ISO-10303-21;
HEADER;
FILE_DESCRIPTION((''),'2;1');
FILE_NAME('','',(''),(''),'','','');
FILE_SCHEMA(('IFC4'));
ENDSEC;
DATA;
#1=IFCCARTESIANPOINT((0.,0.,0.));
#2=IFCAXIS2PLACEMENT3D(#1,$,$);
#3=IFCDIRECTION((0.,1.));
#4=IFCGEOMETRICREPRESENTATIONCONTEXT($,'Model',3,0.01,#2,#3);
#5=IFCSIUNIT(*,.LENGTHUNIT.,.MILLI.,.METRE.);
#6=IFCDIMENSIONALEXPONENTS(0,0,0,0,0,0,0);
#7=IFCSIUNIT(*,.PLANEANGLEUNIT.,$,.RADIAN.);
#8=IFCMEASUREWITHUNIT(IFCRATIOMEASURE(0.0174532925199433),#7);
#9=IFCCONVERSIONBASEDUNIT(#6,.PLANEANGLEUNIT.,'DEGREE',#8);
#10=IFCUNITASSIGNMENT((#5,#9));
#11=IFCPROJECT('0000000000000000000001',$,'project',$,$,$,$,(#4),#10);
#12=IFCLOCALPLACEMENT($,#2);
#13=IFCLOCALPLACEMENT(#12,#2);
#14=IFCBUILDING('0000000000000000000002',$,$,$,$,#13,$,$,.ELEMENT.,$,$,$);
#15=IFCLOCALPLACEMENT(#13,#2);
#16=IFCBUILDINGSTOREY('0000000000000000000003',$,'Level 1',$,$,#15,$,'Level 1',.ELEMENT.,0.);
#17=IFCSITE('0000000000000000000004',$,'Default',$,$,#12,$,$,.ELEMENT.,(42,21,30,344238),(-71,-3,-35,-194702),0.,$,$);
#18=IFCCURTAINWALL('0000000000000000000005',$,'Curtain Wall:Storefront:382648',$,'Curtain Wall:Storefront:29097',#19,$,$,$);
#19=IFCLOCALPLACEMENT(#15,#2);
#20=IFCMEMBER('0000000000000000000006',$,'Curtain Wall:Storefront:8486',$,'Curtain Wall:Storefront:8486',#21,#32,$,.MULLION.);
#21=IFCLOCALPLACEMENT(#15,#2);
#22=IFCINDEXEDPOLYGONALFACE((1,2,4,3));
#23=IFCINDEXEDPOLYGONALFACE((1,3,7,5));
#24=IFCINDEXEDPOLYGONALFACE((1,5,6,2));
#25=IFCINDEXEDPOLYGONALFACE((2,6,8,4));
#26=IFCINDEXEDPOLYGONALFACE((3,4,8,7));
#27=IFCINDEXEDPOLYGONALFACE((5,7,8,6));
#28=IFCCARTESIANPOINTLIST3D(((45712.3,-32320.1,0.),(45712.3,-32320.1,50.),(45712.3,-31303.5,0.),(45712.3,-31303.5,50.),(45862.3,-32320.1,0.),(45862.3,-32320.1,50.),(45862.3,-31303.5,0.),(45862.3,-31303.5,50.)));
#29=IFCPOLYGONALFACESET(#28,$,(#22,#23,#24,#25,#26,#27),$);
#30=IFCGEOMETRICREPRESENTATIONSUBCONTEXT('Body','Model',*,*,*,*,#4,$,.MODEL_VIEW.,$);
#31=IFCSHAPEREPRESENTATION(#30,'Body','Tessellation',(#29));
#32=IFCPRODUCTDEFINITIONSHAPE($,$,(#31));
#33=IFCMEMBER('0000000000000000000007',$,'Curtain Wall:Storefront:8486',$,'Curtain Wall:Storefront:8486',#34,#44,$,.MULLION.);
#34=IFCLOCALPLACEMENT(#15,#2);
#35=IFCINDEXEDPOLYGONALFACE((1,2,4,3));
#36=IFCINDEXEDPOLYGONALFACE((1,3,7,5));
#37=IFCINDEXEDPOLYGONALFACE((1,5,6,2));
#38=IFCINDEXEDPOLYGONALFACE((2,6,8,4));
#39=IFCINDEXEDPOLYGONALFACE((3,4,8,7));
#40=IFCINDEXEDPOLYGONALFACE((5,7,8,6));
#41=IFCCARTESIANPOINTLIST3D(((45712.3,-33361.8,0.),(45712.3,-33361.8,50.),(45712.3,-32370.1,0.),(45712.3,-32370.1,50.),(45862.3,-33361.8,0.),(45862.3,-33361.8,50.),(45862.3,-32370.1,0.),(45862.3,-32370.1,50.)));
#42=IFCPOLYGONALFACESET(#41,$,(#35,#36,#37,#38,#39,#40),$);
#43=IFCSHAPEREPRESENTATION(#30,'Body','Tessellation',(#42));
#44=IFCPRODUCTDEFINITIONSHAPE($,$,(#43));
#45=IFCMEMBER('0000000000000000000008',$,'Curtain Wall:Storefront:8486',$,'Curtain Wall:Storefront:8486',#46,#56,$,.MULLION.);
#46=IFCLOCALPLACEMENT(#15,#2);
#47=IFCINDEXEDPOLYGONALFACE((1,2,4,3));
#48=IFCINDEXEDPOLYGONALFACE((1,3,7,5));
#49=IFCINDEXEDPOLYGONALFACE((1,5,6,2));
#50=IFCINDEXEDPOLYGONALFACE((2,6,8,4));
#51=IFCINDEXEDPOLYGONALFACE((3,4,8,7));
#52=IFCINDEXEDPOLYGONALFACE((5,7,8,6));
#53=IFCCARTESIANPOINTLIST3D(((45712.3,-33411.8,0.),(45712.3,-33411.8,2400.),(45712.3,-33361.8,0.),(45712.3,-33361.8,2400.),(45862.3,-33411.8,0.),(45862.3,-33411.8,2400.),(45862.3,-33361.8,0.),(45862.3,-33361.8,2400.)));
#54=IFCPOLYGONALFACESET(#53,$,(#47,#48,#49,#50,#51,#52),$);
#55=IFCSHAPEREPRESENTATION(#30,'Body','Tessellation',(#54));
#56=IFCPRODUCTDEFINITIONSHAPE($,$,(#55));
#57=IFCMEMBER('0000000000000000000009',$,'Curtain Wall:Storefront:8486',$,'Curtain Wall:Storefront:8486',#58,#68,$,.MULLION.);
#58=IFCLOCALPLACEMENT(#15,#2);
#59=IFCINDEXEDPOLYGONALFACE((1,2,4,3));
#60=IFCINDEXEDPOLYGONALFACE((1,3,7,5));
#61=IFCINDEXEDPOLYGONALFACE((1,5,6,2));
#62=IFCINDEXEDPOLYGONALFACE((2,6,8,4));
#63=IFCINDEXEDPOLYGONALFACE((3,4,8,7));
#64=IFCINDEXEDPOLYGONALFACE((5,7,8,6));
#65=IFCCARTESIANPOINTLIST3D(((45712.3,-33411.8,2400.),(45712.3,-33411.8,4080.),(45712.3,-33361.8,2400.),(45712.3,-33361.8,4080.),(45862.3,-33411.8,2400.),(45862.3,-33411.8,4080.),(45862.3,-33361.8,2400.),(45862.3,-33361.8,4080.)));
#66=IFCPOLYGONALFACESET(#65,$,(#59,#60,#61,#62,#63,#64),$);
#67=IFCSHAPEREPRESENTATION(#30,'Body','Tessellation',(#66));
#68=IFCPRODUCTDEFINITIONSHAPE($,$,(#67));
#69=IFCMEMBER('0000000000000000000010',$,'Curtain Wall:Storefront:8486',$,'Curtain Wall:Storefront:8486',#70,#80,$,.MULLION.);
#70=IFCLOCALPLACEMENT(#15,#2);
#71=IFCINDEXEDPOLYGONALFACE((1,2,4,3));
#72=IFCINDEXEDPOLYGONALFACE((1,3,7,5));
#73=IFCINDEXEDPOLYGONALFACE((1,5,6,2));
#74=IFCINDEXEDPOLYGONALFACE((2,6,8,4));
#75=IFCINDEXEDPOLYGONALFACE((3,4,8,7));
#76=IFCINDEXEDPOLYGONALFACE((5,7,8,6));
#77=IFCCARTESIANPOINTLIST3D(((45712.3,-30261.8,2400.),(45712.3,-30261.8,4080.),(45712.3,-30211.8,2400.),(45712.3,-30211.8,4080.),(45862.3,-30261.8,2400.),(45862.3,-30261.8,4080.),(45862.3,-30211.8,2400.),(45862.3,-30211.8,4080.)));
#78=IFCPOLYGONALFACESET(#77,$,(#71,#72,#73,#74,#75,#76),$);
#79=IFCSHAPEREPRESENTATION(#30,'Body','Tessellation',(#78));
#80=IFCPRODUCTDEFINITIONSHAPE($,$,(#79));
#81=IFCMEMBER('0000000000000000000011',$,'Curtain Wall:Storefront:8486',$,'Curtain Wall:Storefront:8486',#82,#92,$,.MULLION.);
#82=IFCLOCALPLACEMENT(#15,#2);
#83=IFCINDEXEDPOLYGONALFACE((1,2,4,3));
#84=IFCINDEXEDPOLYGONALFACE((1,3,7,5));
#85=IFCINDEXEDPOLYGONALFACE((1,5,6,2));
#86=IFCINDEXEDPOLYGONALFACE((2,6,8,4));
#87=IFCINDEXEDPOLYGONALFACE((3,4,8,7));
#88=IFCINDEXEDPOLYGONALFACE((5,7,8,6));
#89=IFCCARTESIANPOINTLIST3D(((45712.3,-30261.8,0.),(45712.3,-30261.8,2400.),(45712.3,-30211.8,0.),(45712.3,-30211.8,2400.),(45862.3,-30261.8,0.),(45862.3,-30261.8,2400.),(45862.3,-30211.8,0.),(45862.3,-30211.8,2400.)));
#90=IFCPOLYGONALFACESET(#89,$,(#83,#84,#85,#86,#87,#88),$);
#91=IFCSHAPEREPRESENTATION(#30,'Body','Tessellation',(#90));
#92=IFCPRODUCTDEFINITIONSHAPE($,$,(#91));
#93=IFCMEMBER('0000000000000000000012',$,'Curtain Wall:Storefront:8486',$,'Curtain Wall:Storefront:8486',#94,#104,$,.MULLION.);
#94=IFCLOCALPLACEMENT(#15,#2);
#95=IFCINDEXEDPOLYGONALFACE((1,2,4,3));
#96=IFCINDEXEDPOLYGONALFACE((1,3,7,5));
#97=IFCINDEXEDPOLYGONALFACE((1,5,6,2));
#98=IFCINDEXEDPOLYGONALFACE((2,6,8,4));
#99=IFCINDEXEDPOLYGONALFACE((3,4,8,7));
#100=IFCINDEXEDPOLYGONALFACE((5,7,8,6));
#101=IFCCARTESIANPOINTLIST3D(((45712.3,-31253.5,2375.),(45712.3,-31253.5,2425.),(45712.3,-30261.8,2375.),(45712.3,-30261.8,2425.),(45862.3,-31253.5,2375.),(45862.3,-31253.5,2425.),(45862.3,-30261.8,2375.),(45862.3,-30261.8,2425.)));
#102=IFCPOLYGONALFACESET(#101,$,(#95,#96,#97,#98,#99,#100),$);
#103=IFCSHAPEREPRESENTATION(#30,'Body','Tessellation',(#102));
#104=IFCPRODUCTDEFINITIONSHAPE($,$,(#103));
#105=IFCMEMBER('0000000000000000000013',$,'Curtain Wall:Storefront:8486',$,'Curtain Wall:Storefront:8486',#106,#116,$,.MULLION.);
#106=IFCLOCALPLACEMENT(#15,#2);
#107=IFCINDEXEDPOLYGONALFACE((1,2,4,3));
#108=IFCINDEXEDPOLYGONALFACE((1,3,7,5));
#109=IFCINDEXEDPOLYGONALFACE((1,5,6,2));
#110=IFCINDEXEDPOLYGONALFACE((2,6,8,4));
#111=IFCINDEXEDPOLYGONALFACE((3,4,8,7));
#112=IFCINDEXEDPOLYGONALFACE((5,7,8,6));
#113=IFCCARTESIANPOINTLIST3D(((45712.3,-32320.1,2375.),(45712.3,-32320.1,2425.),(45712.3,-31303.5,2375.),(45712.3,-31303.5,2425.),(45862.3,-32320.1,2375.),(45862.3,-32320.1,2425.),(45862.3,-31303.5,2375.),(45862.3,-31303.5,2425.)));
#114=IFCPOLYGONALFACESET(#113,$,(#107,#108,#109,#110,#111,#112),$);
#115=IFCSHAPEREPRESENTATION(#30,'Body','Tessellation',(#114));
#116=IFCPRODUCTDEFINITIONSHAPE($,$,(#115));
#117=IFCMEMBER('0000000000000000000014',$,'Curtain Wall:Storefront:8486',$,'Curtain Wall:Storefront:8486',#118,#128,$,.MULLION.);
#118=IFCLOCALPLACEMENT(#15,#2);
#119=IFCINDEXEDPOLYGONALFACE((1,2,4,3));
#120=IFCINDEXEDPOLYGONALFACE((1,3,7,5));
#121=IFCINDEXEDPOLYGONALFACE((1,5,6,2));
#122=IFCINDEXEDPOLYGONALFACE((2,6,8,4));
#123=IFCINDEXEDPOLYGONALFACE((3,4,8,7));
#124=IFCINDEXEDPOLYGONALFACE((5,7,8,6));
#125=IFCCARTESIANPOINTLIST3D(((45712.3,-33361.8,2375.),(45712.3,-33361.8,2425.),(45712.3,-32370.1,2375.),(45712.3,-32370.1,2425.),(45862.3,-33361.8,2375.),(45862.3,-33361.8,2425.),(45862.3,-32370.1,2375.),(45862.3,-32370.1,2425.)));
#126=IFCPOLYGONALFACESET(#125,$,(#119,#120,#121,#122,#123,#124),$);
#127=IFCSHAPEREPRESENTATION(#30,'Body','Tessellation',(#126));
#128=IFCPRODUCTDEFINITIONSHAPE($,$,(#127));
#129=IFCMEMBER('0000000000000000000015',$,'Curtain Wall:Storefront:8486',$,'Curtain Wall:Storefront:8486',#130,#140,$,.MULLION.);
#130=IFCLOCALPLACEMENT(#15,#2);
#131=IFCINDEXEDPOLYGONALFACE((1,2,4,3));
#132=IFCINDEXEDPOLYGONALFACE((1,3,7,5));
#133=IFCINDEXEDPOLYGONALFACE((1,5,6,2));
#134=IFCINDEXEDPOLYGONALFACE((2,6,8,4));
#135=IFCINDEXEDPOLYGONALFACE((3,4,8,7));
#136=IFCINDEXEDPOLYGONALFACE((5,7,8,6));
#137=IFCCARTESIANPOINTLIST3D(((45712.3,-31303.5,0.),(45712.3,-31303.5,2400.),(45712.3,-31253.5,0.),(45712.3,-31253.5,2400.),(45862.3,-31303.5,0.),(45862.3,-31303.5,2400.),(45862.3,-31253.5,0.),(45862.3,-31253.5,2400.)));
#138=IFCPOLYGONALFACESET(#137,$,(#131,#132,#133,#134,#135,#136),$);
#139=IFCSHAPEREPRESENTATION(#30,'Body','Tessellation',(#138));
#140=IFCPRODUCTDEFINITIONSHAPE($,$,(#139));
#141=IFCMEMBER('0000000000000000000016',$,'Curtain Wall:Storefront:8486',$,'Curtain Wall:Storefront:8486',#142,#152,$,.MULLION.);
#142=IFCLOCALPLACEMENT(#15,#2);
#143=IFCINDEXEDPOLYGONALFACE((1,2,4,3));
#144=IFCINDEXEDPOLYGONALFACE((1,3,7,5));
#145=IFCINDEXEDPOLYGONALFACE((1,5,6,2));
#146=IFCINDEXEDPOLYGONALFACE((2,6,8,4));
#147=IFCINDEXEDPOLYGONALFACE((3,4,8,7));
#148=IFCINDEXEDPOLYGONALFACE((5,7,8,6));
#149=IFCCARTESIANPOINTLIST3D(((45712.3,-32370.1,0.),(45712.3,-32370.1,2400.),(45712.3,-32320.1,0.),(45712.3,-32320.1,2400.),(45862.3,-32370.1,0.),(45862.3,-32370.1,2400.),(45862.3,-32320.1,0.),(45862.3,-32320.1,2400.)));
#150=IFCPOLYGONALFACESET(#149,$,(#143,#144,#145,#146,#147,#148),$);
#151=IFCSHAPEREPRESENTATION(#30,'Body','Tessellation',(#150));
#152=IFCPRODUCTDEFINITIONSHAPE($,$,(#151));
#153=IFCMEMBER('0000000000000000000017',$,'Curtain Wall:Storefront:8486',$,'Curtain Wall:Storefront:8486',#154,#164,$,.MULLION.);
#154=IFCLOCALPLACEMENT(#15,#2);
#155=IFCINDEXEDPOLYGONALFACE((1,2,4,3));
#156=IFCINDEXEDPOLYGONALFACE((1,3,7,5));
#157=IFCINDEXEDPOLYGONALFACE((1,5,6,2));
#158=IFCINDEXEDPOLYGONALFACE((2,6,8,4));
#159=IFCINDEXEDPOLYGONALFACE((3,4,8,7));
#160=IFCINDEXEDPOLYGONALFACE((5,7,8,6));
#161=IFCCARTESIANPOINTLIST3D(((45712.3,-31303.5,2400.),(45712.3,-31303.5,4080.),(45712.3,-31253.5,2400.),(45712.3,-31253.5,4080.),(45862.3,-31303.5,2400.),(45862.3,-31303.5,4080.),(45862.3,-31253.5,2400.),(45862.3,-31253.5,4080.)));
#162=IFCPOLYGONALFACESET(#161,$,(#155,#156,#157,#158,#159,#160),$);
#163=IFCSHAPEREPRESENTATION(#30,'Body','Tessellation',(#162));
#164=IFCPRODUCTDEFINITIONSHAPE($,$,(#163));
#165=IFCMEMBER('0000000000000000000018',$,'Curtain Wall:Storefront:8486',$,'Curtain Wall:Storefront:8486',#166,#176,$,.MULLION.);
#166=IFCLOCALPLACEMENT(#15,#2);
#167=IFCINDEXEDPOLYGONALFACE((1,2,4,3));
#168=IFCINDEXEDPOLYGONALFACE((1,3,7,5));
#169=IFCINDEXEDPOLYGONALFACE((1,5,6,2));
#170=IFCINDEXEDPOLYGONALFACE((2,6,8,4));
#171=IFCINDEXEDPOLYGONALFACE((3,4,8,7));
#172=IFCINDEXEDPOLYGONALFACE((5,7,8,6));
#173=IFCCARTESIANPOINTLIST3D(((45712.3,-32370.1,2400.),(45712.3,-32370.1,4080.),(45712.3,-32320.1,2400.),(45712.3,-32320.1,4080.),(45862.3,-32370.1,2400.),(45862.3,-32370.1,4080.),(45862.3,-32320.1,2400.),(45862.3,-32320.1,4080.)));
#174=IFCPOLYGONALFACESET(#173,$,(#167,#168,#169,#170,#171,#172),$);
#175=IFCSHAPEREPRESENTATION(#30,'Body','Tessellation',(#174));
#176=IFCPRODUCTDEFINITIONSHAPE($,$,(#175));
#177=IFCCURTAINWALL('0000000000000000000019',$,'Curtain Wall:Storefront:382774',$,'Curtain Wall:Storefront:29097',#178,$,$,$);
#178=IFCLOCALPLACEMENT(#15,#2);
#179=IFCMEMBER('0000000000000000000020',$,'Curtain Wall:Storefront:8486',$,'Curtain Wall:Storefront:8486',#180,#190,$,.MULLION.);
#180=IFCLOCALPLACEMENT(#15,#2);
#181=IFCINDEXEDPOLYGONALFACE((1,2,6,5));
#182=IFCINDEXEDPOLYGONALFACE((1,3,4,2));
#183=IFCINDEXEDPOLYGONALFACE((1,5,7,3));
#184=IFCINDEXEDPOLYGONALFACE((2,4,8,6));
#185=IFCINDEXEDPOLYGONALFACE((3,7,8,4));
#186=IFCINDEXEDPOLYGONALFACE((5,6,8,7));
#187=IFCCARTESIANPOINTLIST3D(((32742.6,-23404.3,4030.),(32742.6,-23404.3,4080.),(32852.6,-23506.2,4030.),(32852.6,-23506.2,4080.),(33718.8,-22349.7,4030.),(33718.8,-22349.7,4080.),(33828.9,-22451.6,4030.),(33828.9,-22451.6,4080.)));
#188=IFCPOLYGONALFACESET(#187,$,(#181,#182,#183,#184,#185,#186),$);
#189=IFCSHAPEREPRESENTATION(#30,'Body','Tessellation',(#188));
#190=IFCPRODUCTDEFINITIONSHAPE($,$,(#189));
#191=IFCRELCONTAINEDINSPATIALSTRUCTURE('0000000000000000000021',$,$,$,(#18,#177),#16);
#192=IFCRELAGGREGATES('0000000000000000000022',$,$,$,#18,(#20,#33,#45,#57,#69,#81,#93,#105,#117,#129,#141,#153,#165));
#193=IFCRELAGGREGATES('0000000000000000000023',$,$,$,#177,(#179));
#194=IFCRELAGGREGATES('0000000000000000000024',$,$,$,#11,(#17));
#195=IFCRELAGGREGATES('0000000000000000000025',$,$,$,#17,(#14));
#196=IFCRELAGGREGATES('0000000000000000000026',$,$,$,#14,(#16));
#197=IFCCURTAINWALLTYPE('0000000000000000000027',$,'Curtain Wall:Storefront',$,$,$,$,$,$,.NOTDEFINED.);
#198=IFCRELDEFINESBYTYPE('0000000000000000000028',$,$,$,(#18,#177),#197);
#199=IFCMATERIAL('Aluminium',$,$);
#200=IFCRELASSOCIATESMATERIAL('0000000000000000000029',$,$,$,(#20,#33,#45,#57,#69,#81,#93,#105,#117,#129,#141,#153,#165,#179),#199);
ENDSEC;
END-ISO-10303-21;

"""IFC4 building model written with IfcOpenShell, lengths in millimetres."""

from ifc_helpers import new_model, entity, si_unit, converted_unit, direction, frame, frame_2d, origin, origin_2d_with_axis, place, context, subcontext, project, spatial, rectangle, extrude, material, type_object, element, aggregate, save


model = new_model("IFC4")

# Units and contexts
model_context = context("Model", 3, precision=0.01, world=origin(), true_north=direction((0.0, 1.0)))
body_context = subcontext(model_context, "Body", "Model", "MODEL_VIEW")
ifc_project = project(units=[si_unit("LENGTHUNIT", "METRE", prefix="MILLI"), converted_unit("PLANEANGLEUNIT", "DEGREE", entity("IfcRatioMeasure", 0.0174532925199433), si_unit("PLANEANGLEUNIT", "RADIAN"), dimensions=[0, 0, 0, 0, 0, 0, 0])], contexts=[model_context])

# Site, building, storey
site_placement = place(None, origin())
site = spatial("IfcSite", under=ifc_project, at=site_placement, Name="Default", CompositionType="ELEMENT", RefLatitude=(42, 21, 30, 344238), RefLongitude=(-71, -3, -35, -194702), RefElevation=0.0)
building_placement = place(site_placement, origin())
building = spatial("IfcBuilding", under=site, at=building_placement, CompositionType="ELEMENT")
storey_placement = place(building_placement, origin())
storey = spatial("IfcBuildingStorey", under=building, at=storey_placement, Name="Level 1", LongName="Level 1", CompositionType="ELEMENT", Elevation=0.0)

# Curtain walls, members
curtain_wall_type = type_object("IfcCurtainWallType", Name="Curtain Wall:Storefront", PredefinedType="NOTDEFINED")
curtain_wall_1_placement = place(storey_placement, origin())
curtain_wall_1 = element("IfcCurtainWall", 1, at=curtain_wall_1_placement, inside=storey, type_object=curtain_wall_type, Name="Curtain Wall:Storefront:382648", ObjectType="Curtain Wall:Storefront:29097")
ifc_material = material(Name="Aluminium")
member_1_placement = place(curtain_wall_1_placement, origin())
member_1 = element("IfcMember", 2, at=member_1_placement, material=ifc_material, Name="Curtain Wall:Storefront:8486", ObjectType="Curtain Wall:Storefront:8486", PredefinedType="MULLION", context=body_context, shape_type="SweptSolid", body=[
    extrude(rectangle(XDim=50.0, YDim=150.0, at=origin_2d_with_axis()), frame((45787.3, -31303.5, 25.0), z_axis=(0.0, -1.0, 0.0), x_axis=(0.0, 0.0, -1.0)), (0.0, 0.0, 1.0), 1016.7),
])
member_2_placement = place(curtain_wall_1_placement, origin())
member_2 = element("IfcMember", 3, at=member_2_placement, material=ifc_material, Name="Curtain Wall:Storefront:8486", ObjectType="Curtain Wall:Storefront:8486", PredefinedType="MULLION", context=body_context, shape_type="SweptSolid", body=[
    extrude(rectangle(XDim=50.0, YDim=150.0, at=origin_2d_with_axis()), frame((45787.3, -32370.1, 25.0), z_axis=(0.0, -1.0, 0.0), x_axis=(0.0, 0.0, -1.0)), (0.0, 0.0, 1.0), 991.7),
])
member_3_placement = place(curtain_wall_1_placement, origin())
member_3 = element("IfcMember", 4, at=member_3_placement, material=ifc_material, Name="Curtain Wall:Storefront:8486", ObjectType="Curtain Wall:Storefront:8486", PredefinedType="MULLION", context=body_context, shape_type="SweptSolid", body=[
    extrude(rectangle(XDim=150.0, YDim=50.0, at=frame_2d((0.0, 0.0), x_axis=(1.0, 0.0))), frame((45787.3, -33386.8, 0.0), z_axis=(0.0, 0.0, 1.0), x_axis=(-1.0, 0.0, 0.0)), (0.0, 0.0, 1.0), 2400.0),
])
member_4_placement = place(curtain_wall_1_placement, origin())
member_4 = element("IfcMember", 5, at=member_4_placement, material=ifc_material, Name="Curtain Wall:Storefront:8486", ObjectType="Curtain Wall:Storefront:8486", PredefinedType="MULLION", context=body_context, shape_type="SweptSolid", body=[
    extrude(rectangle(XDim=150.0, YDim=50.0, at=frame_2d((0.0, 0.0), x_axis=(1.0, 0.0))), frame((45787.3, -33386.8, 2400.0), z_axis=(0.0, 0.0, 1.0), x_axis=(-1.0, 0.0, 0.0)), (0.0, 0.0, 1.0), 1680.0),
])
member_5_placement = place(curtain_wall_1_placement, origin())
member_5 = element("IfcMember", 6, at=member_5_placement, material=ifc_material, Name="Curtain Wall:Storefront:8486", ObjectType="Curtain Wall:Storefront:8486", PredefinedType="MULLION", context=body_context, shape_type="SweptSolid", body=[
    extrude(rectangle(XDim=150.0, YDim=50.0, at=frame_2d((0.0, 0.0), x_axis=(1.0, 0.0))), frame((45787.3, -30236.8, 4080.0), z_axis=(0.0, 0.0, -1.0), x_axis=(-1.0, 0.0, 0.0)), (0.0, 0.0, 1.0), 1680.0),
])
member_6_placement = place(curtain_wall_1_placement, origin())
member_6 = element("IfcMember", 7, at=member_6_placement, material=ifc_material, Name="Curtain Wall:Storefront:8486", ObjectType="Curtain Wall:Storefront:8486", PredefinedType="MULLION", context=body_context, shape_type="SweptSolid", body=[
    extrude(rectangle(XDim=150.0, YDim=50.0, at=frame_2d((0.0, 0.0), x_axis=(1.0, 0.0))), frame((45787.3, -30236.8, 2400.0), z_axis=(0.0, 0.0, -1.0), x_axis=(-1.0, 0.0, 0.0)), (0.0, 0.0, 1.0), 2400.0),
])
member_7_placement = place(curtain_wall_1_placement, origin())
member_7 = element("IfcMember", 8, at=member_7_placement, material=ifc_material, Name="Curtain Wall:Storefront:8486", ObjectType="Curtain Wall:Storefront:8486", PredefinedType="MULLION", context=body_context, shape_type="SweptSolid", body=[
    extrude(rectangle(XDim=50.0, YDim=150.0, at=origin_2d_with_axis()), frame((45787.3, -31253.5, 2400.0), z_axis=(0.0, 1.0, 0.0), x_axis=(0.0, 0.0, -1.0)), (0.0, 0.0, 1.0), 991.7),
])
member_8_placement = place(curtain_wall_1_placement, origin())
member_8 = element("IfcMember", 9, at=member_8_placement, material=ifc_material, Name="Curtain Wall:Storefront:8486", ObjectType="Curtain Wall:Storefront:8486", PredefinedType="MULLION", context=body_context, shape_type="SweptSolid", body=[
    extrude(rectangle(XDim=50.0, YDim=150.0, at=origin_2d_with_axis()), frame((45787.3, -32320.1, 2400.0), z_axis=(0.0, 1.0, 0.0), x_axis=(0.0, 0.0, -1.0)), (0.0, 0.0, 1.0), 1016.7),
])
member_9_placement = place(curtain_wall_1_placement, origin())
member_9 = element("IfcMember", 10, at=member_9_placement, material=ifc_material, Name="Curtain Wall:Storefront:8486", ObjectType="Curtain Wall:Storefront:8486", PredefinedType="MULLION", context=body_context, shape_type="SweptSolid", body=[
    extrude(rectangle(XDim=50.0, YDim=150.0, at=origin_2d_with_axis()), frame((45787.3, -33361.8, 2400.0), z_axis=(0.0, 1.0, 0.0), x_axis=(0.0, 0.0, -1.0)), (0.0, 0.0, 1.0), 991.7),
])
member_10_placement = place(curtain_wall_1_placement, origin())
member_10 = element("IfcMember", 11, at=member_10_placement, material=ifc_material, Name="Curtain Wall:Storefront:8486", ObjectType="Curtain Wall:Storefront:8486", PredefinedType="MULLION", context=body_context, shape_type="SweptSolid", body=[
    extrude(rectangle(XDim=150.0, YDim=50.0, at=origin_2d_with_axis()), frame((45787.3, -31278.5, 0.0), z_axis=(0.0, 0.0, 1.0), x_axis=(-1.0, 0.0, 0.0)), (0.0, 0.0, 1.0), 2400.0),
])
member_11_placement = place(curtain_wall_1_placement, origin())
member_11 = element("IfcMember", 12, at=member_11_placement, material=ifc_material, Name="Curtain Wall:Storefront:8486", ObjectType="Curtain Wall:Storefront:8486", PredefinedType="MULLION", context=body_context, shape_type="SweptSolid", body=[
    extrude(rectangle(XDim=150.0, YDim=50.0, at=origin_2d_with_axis()), frame((45787.3, -32345.1, 0.0), z_axis=(0.0, 0.0, 1.0), x_axis=(-1.0, 0.0, 0.0)), (0.0, 0.0, 1.0), 2400.0),
])
member_12_placement = place(curtain_wall_1_placement, origin())
member_12 = element("IfcMember", 13, at=member_12_placement, material=ifc_material, Name="Curtain Wall:Storefront:8486", ObjectType="Curtain Wall:Storefront:8486", PredefinedType="MULLION", context=body_context, shape_type="SweptSolid", body=[
    extrude(rectangle(XDim=150.0, YDim=50.0, at=origin_2d_with_axis()), frame((45787.3, -31278.5, 2400.0), z_axis=(0.0, 0.0, 1.0), x_axis=(-1.0, 0.0, 0.0)), (0.0, 0.0, 1.0), 1680.0),
])
member_13_placement = place(curtain_wall_1_placement, origin())
member_13 = element("IfcMember", 14, at=member_13_placement, material=ifc_material, Name="Curtain Wall:Storefront:8486", ObjectType="Curtain Wall:Storefront:8486", PredefinedType="MULLION", context=body_context, shape_type="SweptSolid", body=[
    extrude(rectangle(XDim=150.0, YDim=50.0, at=origin_2d_with_axis()), frame((45787.3, -32345.1, 2400.0), z_axis=(0.0, 0.0, 1.0), x_axis=(-1.0, 0.0, 0.0)), (0.0, 0.0, 1.0), 1680.0),
])
aggregate(curtain_wall_1, [member_1, member_2, member_3, member_4, member_5, member_6, member_7, member_8, member_9, member_10, member_11, member_12, member_13])
curtain_wall_2_placement = place(storey_placement, origin())
curtain_wall_2 = element("IfcCurtainWall", 15, at=curtain_wall_2_placement, inside=storey, type_object=curtain_wall_type, Name="Curtain Wall:Storefront:382774", ObjectType="Curtain Wall:Storefront:29097")
member_14_placement = place(curtain_wall_2_placement, origin())
member_14 = element("IfcMember", 16, at=member_14_placement, material=ifc_material, Name="Curtain Wall:Storefront:8486", ObjectType="Curtain Wall:Storefront:8486", PredefinedType="MULLION", context=body_context, shape_type="SweptSolid", body=[
    extrude(rectangle(XDim=50.0, YDim=150.0, at=frame_2d((0.0, 0.0), x_axis=(1.0, 0.0))), frame((33773.9, -22400.6, 4055.0), z_axis=(-0.679334, -0.733829, 0.0), x_axis=(0.0, 0.0, -1.0)), (0.0, 0.0, 1.0), 1437.1),
])
aggregate(curtain_wall_2, [member_14])

save(model, "model.ifc")
